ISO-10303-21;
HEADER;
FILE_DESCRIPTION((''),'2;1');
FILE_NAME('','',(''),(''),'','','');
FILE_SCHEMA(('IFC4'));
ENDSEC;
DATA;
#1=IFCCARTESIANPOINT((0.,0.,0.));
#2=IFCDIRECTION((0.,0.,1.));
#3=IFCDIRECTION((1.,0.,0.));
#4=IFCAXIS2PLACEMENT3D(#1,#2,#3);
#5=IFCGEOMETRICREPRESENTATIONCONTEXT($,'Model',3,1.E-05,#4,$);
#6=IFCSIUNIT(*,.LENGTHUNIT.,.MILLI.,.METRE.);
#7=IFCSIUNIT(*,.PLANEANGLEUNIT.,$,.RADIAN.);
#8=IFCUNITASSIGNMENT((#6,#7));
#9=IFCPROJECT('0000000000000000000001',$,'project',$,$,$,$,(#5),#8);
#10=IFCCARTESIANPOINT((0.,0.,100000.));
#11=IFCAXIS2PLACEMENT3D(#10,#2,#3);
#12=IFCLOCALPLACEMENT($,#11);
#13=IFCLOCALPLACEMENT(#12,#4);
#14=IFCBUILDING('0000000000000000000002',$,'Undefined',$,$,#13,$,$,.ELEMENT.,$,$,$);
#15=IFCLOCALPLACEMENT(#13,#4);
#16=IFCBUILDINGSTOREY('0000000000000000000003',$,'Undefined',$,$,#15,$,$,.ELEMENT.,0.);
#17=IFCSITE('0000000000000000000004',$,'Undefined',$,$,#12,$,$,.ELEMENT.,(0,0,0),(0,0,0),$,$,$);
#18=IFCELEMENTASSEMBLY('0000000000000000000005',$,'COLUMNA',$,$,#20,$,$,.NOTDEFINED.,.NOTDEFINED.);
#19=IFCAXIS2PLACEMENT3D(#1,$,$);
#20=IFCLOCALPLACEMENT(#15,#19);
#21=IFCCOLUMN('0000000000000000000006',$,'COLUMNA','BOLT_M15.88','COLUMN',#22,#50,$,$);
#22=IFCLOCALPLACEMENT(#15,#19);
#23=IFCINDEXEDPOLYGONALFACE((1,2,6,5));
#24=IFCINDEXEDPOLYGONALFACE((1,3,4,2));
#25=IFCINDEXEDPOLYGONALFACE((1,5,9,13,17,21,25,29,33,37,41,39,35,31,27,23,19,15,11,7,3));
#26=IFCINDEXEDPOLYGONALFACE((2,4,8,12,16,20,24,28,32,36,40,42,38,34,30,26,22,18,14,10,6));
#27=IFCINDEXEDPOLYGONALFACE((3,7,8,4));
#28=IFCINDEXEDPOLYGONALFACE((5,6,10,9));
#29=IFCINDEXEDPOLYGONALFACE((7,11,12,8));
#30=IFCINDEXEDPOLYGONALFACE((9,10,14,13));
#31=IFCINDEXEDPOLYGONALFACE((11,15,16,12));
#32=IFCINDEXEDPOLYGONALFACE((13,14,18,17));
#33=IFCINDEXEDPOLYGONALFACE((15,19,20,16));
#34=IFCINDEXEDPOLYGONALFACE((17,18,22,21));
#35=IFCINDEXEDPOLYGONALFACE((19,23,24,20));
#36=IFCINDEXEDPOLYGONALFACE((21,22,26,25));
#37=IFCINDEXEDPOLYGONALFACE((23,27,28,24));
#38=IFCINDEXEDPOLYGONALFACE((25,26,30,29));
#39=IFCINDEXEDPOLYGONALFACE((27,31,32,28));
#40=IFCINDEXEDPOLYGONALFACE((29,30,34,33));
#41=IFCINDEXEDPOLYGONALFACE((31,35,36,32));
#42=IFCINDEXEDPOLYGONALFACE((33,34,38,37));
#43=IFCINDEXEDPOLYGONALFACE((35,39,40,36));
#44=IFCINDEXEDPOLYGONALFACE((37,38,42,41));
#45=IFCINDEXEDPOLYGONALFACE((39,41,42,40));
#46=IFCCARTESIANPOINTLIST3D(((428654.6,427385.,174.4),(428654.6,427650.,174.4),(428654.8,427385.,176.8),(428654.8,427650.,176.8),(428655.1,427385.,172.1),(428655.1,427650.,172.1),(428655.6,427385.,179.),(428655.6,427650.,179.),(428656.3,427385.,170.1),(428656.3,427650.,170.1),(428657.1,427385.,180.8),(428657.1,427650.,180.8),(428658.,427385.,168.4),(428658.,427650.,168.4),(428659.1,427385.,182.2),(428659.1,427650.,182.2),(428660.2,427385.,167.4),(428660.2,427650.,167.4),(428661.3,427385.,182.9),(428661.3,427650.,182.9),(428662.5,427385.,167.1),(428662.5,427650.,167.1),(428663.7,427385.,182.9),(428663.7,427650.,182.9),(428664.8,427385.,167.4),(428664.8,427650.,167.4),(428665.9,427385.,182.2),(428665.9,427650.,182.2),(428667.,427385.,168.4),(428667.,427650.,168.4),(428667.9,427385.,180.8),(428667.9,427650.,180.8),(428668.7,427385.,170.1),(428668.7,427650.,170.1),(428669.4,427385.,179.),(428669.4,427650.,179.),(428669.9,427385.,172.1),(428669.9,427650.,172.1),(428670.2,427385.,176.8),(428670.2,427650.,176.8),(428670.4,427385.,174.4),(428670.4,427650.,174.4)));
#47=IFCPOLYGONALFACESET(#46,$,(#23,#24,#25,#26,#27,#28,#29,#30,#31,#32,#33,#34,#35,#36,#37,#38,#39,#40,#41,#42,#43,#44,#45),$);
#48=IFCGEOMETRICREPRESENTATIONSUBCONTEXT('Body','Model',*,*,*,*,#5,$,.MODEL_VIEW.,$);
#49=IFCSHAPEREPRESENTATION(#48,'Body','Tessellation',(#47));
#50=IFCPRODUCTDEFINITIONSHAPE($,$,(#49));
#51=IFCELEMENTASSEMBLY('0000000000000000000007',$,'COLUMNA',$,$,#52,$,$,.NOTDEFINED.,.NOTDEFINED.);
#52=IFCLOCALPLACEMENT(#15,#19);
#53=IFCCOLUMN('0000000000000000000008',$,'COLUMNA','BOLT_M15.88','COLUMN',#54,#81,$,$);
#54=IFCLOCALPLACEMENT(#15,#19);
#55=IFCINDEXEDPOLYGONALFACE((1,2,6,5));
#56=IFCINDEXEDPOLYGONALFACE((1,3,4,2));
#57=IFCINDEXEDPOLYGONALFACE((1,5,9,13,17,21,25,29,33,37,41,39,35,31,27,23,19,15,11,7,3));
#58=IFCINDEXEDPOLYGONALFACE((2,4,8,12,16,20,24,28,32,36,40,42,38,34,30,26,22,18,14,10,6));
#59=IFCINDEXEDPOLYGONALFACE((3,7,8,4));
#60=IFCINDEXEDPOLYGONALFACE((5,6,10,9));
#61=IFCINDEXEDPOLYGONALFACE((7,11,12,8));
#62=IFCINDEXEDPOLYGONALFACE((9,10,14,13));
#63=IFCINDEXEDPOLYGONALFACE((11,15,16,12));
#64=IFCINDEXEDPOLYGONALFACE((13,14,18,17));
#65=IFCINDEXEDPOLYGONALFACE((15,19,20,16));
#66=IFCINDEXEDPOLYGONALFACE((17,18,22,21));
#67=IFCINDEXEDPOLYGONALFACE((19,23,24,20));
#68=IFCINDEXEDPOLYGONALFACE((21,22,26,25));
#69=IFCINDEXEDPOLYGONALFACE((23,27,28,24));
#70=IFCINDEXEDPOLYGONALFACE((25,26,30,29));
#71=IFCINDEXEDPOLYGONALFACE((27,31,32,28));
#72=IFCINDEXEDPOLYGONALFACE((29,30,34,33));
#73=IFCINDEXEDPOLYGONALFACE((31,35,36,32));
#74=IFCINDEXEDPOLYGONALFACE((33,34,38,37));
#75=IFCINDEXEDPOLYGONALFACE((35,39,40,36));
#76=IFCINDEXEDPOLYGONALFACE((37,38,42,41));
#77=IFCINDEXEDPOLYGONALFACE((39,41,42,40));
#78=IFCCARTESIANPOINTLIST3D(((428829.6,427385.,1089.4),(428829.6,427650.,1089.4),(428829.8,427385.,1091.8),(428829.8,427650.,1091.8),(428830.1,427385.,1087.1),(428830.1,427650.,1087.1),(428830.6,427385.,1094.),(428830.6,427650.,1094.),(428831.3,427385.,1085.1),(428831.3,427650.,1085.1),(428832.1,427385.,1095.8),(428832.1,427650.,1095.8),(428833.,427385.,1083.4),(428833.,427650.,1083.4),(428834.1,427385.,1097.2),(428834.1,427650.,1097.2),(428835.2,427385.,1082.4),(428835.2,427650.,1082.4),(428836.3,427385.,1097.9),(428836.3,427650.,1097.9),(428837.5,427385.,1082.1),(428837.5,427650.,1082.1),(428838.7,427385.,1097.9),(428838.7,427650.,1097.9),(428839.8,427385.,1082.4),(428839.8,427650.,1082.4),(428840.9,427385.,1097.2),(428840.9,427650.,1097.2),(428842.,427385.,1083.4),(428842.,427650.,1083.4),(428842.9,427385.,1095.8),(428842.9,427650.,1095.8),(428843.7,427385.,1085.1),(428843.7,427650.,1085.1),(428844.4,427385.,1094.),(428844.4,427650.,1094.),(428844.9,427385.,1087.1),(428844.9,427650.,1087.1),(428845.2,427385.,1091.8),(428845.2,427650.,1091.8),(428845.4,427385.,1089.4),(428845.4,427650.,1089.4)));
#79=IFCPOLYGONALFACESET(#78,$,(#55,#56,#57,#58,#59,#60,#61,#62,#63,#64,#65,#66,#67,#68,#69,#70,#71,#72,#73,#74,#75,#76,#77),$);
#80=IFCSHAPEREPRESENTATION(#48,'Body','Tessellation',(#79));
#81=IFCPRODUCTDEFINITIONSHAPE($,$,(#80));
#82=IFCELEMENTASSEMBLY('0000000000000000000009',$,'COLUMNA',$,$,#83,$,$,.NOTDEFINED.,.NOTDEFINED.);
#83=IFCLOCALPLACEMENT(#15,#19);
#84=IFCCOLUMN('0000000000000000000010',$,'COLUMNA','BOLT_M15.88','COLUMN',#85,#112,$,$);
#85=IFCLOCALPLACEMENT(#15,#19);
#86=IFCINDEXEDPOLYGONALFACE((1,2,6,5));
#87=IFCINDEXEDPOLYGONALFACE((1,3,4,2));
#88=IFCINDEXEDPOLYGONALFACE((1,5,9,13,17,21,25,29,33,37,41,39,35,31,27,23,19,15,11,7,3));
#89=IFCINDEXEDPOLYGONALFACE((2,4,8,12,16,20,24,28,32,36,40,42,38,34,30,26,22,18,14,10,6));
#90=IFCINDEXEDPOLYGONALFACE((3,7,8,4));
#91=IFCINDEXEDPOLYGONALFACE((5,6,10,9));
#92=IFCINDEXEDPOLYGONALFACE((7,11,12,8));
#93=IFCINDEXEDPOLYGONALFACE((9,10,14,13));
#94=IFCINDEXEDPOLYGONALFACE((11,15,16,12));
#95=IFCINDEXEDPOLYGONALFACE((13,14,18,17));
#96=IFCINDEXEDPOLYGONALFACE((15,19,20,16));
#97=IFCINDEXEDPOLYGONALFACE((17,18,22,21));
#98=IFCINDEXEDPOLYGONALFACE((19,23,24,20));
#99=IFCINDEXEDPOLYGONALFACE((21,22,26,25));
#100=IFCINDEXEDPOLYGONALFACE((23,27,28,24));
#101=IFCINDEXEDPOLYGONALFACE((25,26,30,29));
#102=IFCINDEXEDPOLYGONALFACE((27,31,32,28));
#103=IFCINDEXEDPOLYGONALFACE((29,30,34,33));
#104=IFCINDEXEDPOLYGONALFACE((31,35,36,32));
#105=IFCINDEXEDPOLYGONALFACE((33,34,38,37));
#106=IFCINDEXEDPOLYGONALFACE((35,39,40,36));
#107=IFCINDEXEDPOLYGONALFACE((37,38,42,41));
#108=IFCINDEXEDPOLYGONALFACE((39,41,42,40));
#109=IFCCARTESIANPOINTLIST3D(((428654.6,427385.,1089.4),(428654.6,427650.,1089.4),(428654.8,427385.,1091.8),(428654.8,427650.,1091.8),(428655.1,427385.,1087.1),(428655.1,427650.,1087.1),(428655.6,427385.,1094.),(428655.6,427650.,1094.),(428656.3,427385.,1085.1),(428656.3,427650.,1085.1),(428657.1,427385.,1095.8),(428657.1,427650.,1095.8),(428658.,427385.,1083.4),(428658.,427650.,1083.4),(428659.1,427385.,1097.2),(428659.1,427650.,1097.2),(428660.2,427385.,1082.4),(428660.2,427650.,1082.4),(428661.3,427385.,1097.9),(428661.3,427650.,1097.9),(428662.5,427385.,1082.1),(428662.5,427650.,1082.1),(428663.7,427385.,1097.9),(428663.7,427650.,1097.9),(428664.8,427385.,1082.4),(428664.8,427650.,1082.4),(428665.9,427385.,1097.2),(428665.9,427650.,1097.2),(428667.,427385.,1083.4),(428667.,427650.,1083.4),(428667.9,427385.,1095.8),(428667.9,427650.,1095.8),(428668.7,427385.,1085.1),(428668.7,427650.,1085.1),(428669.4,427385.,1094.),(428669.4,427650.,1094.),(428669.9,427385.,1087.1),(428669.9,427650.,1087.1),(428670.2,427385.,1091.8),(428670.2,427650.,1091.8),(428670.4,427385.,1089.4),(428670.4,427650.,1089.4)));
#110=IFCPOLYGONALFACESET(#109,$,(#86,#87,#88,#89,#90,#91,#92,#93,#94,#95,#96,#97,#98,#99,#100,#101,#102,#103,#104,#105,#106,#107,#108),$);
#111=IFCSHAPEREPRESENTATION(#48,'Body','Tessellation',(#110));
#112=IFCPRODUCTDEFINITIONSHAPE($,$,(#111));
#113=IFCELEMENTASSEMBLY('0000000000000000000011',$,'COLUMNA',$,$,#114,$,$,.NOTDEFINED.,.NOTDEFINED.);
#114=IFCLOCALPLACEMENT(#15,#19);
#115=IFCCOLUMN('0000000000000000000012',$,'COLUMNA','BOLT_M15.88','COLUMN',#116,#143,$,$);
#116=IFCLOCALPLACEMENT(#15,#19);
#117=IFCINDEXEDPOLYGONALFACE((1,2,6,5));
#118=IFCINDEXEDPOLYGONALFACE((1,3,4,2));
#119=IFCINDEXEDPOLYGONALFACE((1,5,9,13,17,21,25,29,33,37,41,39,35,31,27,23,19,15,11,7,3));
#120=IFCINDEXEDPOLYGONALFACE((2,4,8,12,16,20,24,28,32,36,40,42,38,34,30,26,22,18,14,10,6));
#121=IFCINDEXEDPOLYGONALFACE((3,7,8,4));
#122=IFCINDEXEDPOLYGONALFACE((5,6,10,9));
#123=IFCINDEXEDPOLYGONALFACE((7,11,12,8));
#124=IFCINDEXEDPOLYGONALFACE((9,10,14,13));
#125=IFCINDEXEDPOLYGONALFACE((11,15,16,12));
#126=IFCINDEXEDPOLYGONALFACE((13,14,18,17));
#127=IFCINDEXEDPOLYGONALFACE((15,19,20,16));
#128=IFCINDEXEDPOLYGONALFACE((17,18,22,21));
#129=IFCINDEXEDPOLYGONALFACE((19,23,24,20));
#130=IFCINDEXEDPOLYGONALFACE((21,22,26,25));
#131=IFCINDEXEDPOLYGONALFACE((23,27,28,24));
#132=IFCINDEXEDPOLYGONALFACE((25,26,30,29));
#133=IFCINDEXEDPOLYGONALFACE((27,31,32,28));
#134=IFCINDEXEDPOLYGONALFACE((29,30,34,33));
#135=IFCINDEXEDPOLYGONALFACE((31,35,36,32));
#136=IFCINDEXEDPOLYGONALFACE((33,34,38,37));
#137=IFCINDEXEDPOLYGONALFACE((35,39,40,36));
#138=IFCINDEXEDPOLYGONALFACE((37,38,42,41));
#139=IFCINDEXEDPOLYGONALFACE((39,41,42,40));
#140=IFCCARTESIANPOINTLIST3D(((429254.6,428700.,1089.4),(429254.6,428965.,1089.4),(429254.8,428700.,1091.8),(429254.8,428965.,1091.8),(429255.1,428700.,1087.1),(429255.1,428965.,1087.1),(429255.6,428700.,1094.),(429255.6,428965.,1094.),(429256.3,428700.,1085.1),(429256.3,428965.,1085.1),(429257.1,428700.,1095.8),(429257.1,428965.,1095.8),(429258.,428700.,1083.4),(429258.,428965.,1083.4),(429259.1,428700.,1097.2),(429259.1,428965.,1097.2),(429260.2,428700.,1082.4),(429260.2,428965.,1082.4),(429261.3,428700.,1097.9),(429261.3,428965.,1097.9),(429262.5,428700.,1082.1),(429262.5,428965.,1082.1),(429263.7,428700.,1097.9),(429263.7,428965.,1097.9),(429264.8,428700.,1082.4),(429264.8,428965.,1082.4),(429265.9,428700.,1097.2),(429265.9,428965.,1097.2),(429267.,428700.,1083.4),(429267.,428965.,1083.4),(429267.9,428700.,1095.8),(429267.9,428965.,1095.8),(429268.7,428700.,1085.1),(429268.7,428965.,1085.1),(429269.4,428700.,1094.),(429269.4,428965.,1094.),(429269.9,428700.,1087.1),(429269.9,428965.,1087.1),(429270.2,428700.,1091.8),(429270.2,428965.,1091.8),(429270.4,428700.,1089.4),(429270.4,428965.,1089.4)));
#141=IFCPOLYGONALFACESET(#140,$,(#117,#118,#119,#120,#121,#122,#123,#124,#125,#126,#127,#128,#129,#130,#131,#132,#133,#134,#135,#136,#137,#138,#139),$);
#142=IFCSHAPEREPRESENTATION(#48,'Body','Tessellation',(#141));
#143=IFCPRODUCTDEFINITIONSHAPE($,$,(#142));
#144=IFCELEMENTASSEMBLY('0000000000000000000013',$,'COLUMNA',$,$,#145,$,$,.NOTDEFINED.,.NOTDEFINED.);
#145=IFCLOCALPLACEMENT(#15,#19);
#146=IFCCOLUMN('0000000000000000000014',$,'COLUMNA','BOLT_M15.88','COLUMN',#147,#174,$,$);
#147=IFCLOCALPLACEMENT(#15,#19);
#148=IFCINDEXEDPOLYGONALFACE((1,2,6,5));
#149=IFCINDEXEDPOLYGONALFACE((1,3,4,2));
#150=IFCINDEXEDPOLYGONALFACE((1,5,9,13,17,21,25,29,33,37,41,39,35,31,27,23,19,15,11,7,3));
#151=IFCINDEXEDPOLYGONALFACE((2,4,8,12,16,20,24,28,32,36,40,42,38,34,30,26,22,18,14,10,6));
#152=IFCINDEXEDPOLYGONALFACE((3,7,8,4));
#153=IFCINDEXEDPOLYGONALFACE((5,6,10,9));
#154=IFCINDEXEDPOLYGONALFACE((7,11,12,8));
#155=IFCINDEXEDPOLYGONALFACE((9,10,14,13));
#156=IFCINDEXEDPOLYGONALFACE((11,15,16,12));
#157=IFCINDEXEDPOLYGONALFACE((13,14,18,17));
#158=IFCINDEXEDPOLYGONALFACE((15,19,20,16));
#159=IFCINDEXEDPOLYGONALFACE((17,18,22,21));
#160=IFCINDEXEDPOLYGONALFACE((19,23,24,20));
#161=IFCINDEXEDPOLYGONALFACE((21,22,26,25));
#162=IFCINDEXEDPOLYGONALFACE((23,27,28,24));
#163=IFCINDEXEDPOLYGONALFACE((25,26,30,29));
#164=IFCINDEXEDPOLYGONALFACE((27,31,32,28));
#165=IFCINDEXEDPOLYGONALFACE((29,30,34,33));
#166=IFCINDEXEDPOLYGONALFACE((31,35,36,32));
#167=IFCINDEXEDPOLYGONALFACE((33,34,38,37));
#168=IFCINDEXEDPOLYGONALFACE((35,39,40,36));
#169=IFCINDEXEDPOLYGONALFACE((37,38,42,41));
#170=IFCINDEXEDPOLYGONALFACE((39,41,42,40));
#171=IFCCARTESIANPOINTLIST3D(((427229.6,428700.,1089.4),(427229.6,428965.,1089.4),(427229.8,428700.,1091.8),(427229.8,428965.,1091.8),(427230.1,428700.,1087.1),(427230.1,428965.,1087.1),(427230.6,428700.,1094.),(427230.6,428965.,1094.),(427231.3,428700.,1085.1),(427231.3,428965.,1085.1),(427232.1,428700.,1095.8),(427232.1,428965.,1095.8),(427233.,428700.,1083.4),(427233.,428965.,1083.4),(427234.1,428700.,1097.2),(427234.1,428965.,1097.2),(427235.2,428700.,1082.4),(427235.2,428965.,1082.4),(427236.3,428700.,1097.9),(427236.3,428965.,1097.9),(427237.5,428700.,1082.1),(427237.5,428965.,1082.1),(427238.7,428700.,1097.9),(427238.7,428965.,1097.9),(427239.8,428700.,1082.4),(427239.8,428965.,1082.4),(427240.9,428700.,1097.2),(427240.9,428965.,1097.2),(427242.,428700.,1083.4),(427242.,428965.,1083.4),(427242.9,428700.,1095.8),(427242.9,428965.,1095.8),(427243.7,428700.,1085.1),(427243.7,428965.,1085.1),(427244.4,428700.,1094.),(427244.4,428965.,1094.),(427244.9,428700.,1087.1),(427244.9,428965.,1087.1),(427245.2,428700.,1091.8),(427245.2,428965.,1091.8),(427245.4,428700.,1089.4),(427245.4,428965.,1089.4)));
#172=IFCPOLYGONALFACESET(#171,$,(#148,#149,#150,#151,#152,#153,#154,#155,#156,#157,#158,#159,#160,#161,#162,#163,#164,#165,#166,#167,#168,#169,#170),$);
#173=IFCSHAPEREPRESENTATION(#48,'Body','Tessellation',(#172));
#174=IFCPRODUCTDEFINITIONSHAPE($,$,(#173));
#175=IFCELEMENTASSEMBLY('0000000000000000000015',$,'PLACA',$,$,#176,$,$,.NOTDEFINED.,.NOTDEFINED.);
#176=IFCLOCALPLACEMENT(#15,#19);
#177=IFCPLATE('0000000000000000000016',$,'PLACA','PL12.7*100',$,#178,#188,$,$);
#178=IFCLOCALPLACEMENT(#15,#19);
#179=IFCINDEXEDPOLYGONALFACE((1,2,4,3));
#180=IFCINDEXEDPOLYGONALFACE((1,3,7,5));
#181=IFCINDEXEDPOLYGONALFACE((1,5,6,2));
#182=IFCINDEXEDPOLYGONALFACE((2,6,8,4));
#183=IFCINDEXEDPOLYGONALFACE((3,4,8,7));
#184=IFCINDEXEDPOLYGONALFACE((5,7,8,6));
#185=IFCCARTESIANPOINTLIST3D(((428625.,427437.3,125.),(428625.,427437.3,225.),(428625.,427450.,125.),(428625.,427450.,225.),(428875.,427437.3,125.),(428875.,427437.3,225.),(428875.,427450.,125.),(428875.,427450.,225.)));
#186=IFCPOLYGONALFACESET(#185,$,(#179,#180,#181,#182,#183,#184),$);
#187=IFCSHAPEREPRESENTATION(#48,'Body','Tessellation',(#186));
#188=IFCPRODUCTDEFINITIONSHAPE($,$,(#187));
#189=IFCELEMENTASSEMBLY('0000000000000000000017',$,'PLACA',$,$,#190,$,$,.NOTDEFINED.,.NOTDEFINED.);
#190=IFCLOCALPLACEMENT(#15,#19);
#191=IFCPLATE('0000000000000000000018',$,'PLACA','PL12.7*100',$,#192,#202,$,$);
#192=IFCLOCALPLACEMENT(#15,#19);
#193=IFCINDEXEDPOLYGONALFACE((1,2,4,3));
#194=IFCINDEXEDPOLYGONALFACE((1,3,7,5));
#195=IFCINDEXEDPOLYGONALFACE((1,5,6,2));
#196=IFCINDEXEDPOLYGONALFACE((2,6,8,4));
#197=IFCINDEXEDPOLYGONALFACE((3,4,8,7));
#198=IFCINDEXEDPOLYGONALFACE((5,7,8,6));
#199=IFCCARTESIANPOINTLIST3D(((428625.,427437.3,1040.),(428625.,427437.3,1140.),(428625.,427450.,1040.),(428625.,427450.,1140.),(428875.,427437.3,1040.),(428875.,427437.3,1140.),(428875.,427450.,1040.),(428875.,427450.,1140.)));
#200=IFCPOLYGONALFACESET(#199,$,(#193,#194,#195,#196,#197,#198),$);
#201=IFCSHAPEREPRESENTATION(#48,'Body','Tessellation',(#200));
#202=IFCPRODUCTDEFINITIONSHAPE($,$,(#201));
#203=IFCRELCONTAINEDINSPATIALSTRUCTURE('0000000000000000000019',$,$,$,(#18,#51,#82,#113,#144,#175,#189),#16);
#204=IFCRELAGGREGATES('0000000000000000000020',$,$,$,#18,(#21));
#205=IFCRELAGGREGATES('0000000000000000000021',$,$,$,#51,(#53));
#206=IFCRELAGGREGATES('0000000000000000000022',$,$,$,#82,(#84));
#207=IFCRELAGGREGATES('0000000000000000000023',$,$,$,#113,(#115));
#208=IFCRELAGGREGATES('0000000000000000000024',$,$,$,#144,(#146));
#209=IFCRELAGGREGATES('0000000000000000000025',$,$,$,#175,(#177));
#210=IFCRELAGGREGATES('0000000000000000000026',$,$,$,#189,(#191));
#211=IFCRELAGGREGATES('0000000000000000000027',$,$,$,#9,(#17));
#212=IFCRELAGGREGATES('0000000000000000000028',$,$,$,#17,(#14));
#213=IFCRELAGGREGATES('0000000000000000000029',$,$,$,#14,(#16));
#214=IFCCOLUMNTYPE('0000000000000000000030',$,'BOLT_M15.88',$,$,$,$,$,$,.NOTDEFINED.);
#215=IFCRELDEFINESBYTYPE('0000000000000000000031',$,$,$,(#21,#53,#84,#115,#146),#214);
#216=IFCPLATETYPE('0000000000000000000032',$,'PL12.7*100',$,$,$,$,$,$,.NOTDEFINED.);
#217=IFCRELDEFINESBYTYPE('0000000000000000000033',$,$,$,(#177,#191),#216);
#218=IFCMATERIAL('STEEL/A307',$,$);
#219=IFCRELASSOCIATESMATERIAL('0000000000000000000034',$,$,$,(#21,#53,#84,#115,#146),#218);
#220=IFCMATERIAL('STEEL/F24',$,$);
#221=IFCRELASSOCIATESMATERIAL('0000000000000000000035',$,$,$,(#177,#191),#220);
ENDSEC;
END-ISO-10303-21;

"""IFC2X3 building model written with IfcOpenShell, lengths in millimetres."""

from ifc_helpers import new_model, si_unit, frame, origin_with_axes, origin_2d_with_axis, place, context, subcontext, project, spatial, polyline, circle, outline, extrude, material, type_object, element, aggregate, save


model = new_model("IFC2X3")

# Units and contexts
model_context = context("Model", 3, precision=1e-05, world=origin_with_axes())
body_context = subcontext(model_context, "Body", "Model", "MODEL_VIEW")
ifc_project = project(units=[si_unit("LENGTHUNIT", "METRE", prefix="MILLI"), si_unit("PLANEANGLEUNIT", "RADIAN")], contexts=[model_context])

# Site, building, storey
site_placement = place(None, frame((0.0, 0.0, 100000.0), z_axis=(0.0, 0.0, 1.0), x_axis=(1.0, 0.0, 0.0)))
site = spatial("IfcSite", under=ifc_project, at=site_placement, Name="Undefined", CompositionType="ELEMENT", RefLatitude=(0, 0, 0), RefLongitude=(0, 0, 0))
building_placement = place(site_placement, origin_with_axes())
building = spatial("IfcBuilding", under=site, at=building_placement, Name="Undefined", CompositionType="ELEMENT")
storey_placement = place(building_placement, origin_with_axes())
storey = spatial("IfcBuildingStorey", under=building, at=storey_placement, Name="Undefined", CompositionType="ELEMENT", Elevation=0.0)

# Element assemblies, columns
ifc_material_1 = material(Name="STEEL/A307")
column_type_1 = type_object("IfcColumnType", Name="BOLT_M15.88", PredefinedType="NOTDEFINED")
assembly_1_placement = place(storey_placement, origin_with_axes())
assembly_1 = element("IfcElementAssembly", 1, at=assembly_1_placement, inside=storey, Name="COLUMNA", AssemblyPlace="NOTDEFINED", PredefinedType="NOTDEFINED")
column_1_placement = place(assembly_1_placement, frame((428662.5, 427650.0, 175.0), z_axis=(0.0, -1.0, -0.000003), x_axis=(-1.0, 0.0, 0.0)))
column_1 = element("IfcColumn", 2, at=column_1_placement, type_object=column_type_1, material=ifc_material_1, Name="COLUMNA", Description="BOLT_M15.88", ObjectType="COLUMN", context=body_context, shape_type="SweptSolid", body=[
    extrude(circle(Radius=7.9, at=origin_2d_with_axis()), frame((0.0, 0.0, 265.0), z_axis=(0.0, 0.0, -1.0), x_axis=(0.0, 1.0, 0.0)), (0.0, 0.0, 1.0), 265.0),
])
aggregate(assembly_1, [column_1])
assembly_2_placement = place(storey_placement, origin_with_axes())
assembly_2 = element("IfcElementAssembly", 3, at=assembly_2_placement, inside=storey, Name="COLUMNA", AssemblyPlace="NOTDEFINED", PredefinedType="NOTDEFINED")
column_2_placement = place(assembly_2_placement, frame((428837.5, 427650.0, 1090.0), z_axis=(0.0, -1.0, -0.000003), x_axis=(-1.0, 0.0, 0.0)))
column_2 = element("IfcColumn", 4, at=column_2_placement, type_object=column_type_1, material=ifc_material_1, Name="COLUMNA", Description="BOLT_M15.88", ObjectType="COLUMN", context=body_context, shape_type="SweptSolid", body=[
    extrude(circle(Radius=7.9, at=origin_2d_with_axis()), frame((0.0, 0.0, 265.0), z_axis=(0.0, 0.0, -1.0), x_axis=(0.0, 1.0, 0.0)), (0.0, 0.0, 1.0), 265.0),
])
aggregate(assembly_2, [column_2])
assembly_3_placement = place(storey_placement, origin_with_axes())
assembly_3 = element("IfcElementAssembly", 5, at=assembly_3_placement, inside=storey, Name="COLUMNA", AssemblyPlace="NOTDEFINED", PredefinedType="NOTDEFINED")
column_3_placement = place(assembly_3_placement, frame((428662.5, 427650.0, 1090.0), z_axis=(0.0, -1.0, -0.000003), x_axis=(-1.0, 0.0, 0.0)))
column_3 = element("IfcColumn", 6, at=column_3_placement, type_object=column_type_1, material=ifc_material_1, Name="COLUMNA", Description="BOLT_M15.88", ObjectType="COLUMN", context=body_context, shape_type="SweptSolid", body=[
    extrude(circle(Radius=7.9, at=origin_2d_with_axis()), frame((0.0, 0.0, 265.0), z_axis=(0.0, 0.0, -1.0), x_axis=(0.0, 1.0, 0.0)), (0.0, 0.0, 1.0), 265.0),
])
aggregate(assembly_3, [column_3])
assembly_4_placement = place(storey_placement, origin_with_axes())
assembly_4 = element("IfcElementAssembly", 7, at=assembly_4_placement, inside=storey, Name="COLUMNA", AssemblyPlace="NOTDEFINED", PredefinedType="NOTDEFINED")
column_4_placement = place(assembly_4_placement, frame((429262.5, 428700.0, 1090.0), z_axis=(0.0, 1.0, -0.000003), x_axis=(1.0, 0.0, 0.0)))
column_4 = element("IfcColumn", 8, at=column_4_placement, type_object=column_type_1, material=ifc_material_1, Name="COLUMNA", Description="BOLT_M15.88", ObjectType="COLUMN", context=body_context, shape_type="SweptSolid", body=[
    extrude(circle(Radius=7.9, at=origin_2d_with_axis()), frame((0.0, 0.0, 265.0), z_axis=(0.0, 0.0, -1.0), x_axis=(0.0, 1.0, 0.0)), (0.0, 0.0, 1.0), 265.0),
])
aggregate(assembly_4, [column_4])
assembly_5_placement = place(storey_placement, origin_with_axes())
assembly_5 = element("IfcElementAssembly", 9, at=assembly_5_placement, inside=storey, Name="COLUMNA", AssemblyPlace="NOTDEFINED", PredefinedType="NOTDEFINED")
column_5_placement = place(assembly_5_placement, frame((427237.5, 428700.0, 1090.0), z_axis=(0.0, 1.0, -0.000003), x_axis=(1.0, 0.0, 0.0)))
column_5 = element("IfcColumn", 10, at=column_5_placement, type_object=column_type_1, material=ifc_material_1, Name="COLUMNA", Description="BOLT_M15.88", ObjectType="COLUMN", context=body_context, shape_type="SweptSolid", body=[
    extrude(circle(Radius=7.9, at=origin_2d_with_axis()), frame((0.0, 0.0, 265.0), z_axis=(0.0, 0.0, -1.0), x_axis=(0.0, 1.0, 0.0)), (0.0, 0.0, 1.0), 265.0),
])
aggregate(assembly_5, [column_5])

# Element assemblies, plates
assembly_6_placement = place(storey_placement, origin_with_axes())
assembly_6 = element("IfcElementAssembly", 11, at=assembly_6_placement, inside=storey, Name="PLACA", AssemblyPlace="NOTDEFINED", PredefinedType="NOTDEFINED")
ifc_material_2 = material(Name="STEEL/F24")
plate_type = type_object("IfcPlateType", Name="PL12.7*100", PredefinedType="NOTDEFINED")
plate_1_placement = place(assembly_6_placement, frame((428625.0, 427443.6, 225.0), z_axis=(0.0, 1.0, 0.0), x_axis=(1.0, 0.0, 0.0)))
plate_1 = element("IfcPlate", 12, at=plate_1_placement, type_object=plate_type, material=ifc_material_2, Name="PLACA", Description="PL12.7*100", context=body_context, shape_type="SweptSolid", body=[
    extrude(outline(polyline([(0.0, 0.0), (250.0, 0.0), (250.0, 100.0), (0.0, 100.0), (0.0, 0.0)])), frame((0.0, 0.0, -6.3), z_axis=(0.0, 0.0, 1.0), x_axis=(1.0, 0.0, 0.0)), (0.0, 0.0, 1.0), 12.7),
])
aggregate(assembly_6, [plate_1])
assembly_7_placement = place(storey_placement, origin_with_axes())
assembly_7 = element("IfcElementAssembly", 13, at=assembly_7_placement, inside=storey, Name="PLACA", AssemblyPlace="NOTDEFINED", PredefinedType="NOTDEFINED")
plate_2_placement = place(assembly_7_placement, frame((428625.0, 427443.6, 1140.0), z_axis=(0.0, 1.0, 0.0), x_axis=(1.0, 0.0, 0.0)))
plate_2 = element("IfcPlate", 14, at=plate_2_placement, type_object=plate_type, material=ifc_material_2, Name="PLACA", Description="PL12.7*100", context=body_context, shape_type="SweptSolid", body=[
    extrude(outline(polyline([(0.0, 0.0), (250.0, 0.0), (250.0, 100.0), (0.0, 100.0), (0.0, 0.0)])), frame((0.0, 0.0, -6.3), z_axis=(0.0, 0.0, 1.0), x_axis=(1.0, 0.0, 0.0)), (0.0, 0.0, 1.0), 12.7),
])
aggregate(assembly_7, [plate_2])

save(model, "model.ifc")
